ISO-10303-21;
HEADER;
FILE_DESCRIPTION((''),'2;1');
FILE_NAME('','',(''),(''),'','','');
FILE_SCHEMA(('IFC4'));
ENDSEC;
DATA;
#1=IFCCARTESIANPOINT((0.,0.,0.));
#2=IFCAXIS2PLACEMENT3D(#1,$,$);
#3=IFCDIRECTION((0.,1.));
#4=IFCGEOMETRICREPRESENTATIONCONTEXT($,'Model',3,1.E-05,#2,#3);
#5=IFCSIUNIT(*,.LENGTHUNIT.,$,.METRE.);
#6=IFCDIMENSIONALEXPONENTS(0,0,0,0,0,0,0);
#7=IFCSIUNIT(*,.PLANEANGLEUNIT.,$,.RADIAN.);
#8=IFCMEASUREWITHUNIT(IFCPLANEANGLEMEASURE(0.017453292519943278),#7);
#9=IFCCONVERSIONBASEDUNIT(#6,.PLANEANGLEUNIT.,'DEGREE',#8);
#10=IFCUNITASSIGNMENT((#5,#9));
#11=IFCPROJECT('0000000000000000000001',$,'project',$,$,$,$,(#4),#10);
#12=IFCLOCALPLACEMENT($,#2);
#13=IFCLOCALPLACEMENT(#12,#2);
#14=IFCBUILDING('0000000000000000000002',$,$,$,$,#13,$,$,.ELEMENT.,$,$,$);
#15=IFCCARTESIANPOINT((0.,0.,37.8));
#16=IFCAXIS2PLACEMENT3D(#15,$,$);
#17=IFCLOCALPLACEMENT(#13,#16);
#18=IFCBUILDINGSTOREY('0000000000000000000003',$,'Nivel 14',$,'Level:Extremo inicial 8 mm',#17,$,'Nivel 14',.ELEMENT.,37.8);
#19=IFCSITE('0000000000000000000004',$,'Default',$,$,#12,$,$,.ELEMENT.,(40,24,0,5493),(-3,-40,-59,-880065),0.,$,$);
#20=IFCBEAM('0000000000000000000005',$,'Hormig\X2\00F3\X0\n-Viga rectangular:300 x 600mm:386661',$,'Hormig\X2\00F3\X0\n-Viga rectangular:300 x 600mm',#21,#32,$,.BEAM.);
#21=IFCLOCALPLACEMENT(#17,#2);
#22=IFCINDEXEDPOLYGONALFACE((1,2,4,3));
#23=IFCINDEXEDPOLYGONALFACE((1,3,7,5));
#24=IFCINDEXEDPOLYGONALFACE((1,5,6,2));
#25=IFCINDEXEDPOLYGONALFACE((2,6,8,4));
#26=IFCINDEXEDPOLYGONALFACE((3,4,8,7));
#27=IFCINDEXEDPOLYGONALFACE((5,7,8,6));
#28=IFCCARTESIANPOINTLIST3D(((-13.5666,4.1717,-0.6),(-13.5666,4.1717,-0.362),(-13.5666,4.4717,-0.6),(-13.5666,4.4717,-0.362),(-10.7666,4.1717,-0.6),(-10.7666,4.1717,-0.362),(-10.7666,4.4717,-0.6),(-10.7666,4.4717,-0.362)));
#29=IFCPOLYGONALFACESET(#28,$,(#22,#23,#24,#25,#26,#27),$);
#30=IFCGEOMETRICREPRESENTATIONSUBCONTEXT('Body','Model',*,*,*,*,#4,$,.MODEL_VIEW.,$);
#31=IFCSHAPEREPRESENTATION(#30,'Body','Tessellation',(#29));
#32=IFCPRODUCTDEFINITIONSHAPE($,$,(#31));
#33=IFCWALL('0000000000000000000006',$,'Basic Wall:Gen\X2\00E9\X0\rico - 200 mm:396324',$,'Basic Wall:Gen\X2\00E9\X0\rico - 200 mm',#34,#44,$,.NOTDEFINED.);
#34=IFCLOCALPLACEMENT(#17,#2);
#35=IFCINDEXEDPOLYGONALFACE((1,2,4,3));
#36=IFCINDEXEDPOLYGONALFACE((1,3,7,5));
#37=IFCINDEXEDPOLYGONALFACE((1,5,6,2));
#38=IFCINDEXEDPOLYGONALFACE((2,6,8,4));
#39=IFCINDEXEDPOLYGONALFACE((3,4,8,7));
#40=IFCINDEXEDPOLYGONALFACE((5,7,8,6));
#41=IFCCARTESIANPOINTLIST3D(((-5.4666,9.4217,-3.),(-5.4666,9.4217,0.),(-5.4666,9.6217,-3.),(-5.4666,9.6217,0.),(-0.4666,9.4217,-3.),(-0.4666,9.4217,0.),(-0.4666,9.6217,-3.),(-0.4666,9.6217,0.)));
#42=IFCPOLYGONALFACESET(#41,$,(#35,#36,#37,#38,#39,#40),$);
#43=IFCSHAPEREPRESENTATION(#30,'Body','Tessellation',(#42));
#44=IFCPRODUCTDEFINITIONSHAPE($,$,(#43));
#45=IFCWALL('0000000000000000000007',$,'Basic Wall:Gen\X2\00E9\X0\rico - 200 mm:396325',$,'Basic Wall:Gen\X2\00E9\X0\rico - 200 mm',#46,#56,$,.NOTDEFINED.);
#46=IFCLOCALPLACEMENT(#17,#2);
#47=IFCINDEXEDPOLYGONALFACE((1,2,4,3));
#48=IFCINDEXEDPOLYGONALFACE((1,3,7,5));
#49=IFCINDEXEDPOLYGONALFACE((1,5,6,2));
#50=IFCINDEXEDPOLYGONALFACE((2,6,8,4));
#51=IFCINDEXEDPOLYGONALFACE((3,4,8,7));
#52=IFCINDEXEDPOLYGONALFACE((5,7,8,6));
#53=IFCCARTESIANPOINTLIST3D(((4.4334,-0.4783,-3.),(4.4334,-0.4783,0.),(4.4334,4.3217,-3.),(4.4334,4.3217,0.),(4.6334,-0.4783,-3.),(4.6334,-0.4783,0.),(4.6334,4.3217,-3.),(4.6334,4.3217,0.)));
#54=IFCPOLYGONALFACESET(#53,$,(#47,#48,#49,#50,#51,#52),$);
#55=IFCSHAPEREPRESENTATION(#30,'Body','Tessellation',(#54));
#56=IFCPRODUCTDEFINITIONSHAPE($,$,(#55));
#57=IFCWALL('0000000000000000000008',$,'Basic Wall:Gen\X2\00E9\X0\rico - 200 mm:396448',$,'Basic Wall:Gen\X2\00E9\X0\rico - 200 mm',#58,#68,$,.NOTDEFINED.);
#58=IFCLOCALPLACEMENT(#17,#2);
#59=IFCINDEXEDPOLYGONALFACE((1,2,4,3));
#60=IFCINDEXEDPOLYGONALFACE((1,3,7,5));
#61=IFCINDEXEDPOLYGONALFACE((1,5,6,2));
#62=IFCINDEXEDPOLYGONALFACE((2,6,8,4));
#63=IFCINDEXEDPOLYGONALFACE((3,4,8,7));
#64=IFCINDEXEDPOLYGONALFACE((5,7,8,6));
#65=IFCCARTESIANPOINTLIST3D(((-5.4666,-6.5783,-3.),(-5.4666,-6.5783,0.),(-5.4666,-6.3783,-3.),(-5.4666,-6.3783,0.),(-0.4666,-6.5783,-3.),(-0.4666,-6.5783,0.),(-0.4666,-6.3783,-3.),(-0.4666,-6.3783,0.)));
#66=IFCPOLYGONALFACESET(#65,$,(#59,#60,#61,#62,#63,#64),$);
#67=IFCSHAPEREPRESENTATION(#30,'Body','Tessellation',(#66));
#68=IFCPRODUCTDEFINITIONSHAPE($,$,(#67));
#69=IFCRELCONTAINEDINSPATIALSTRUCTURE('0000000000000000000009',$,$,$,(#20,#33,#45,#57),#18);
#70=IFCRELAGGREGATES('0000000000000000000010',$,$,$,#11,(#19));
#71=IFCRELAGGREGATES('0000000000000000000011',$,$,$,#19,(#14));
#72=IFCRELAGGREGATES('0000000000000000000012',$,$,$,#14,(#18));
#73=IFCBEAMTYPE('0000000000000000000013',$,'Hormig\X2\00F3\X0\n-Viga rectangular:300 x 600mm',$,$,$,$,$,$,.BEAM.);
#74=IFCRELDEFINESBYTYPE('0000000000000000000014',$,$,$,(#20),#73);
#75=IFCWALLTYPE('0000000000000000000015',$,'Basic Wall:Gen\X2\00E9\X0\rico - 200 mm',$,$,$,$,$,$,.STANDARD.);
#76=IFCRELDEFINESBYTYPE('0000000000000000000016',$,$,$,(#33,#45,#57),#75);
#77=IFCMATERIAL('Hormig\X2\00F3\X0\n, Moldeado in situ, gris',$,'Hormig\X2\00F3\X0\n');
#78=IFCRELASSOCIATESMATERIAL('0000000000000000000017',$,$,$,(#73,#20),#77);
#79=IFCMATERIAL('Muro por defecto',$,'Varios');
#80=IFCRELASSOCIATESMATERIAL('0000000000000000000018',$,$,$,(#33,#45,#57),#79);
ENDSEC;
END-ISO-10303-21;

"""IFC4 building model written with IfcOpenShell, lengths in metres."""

from ifc_helpers import new_model, entity, si_unit, converted_unit, direction, frame, origin, place, context, subcontext, project, spatial, indexed_curve, outline, extrude, source, transform, mapped, material, type_object, type_shapes, element, save


model = new_model("IFC4")

# Units and contexts
model_context = context("Model", 3, precision=1e-05, world=origin(), true_north=direction((0.0, 1.0)))
body_context = subcontext(model_context, "Body", "Model", "MODEL_VIEW")
ifc_project = project(units=[si_unit("LENGTHUNIT", "METRE"), converted_unit("PLANEANGLEUNIT", "DEGREE", entity("IfcPlaneAngleMeasure", 0.017453292519943278), si_unit("PLANEANGLEUNIT", "RADIAN"), dimensions=[0, 0, 0, 0, 0, 0, 0])], contexts=[model_context])

# Site, building, storey
site_placement = place(None, origin())
site = spatial("IfcSite", under=ifc_project, at=site_placement, Name="Default", CompositionType="ELEMENT", RefLatitude=(40, 24, 0, 5493), RefLongitude=(-3, -40, -59, -880065), RefElevation=0.0)
building_placement = place(site_placement, origin())
building = spatial("IfcBuilding", under=site, at=building_placement, CompositionType="ELEMENT")
storey_placement = place(building_placement, frame((0.0, 0.0, 37.8)))
storey = spatial("IfcBuildingStorey", under=building, at=storey_placement, Name="Nivel 14", ObjectType="Level:Extremo inicial 8 mm", LongName="Nivel 14", CompositionType="ELEMENT", Elevation=37.8)

# Shared definitions
ifc_material_1 = material(Name="Hormigón, Moldeado in situ, gris", Category="Hormigón")

# Beam
beam_type_1 = type_object("IfcBeamType", Name="Hormigón-Viga rectangular:300 x 600mm", PredefinedType="BEAM", material=ifc_material_1)
shared_shape_1 = source(origin(), body_context, "Body", "SweptSolid", [
    extrude(outline(indexed_curve([(-0.119, -0.15), (0.119, -0.15), (0.119, 0.15), (-0.119, 0.15), (-0.119, -0.15)], self_intersect=False)), frame((-10.7666, 4.3217, 37.319), z_axis=(-1.0, 0.0, 0.0), x_axis=(0.0, 0.0, -1.0)), (0.0, 0.0, 1.0), 2.8),
])
type_shapes(beam_type_1, [shared_shape_1])
beam_1_placement = place(storey_placement, frame((0.0, 0.0, -37.8)))
element("IfcBeam", 1, at=beam_1_placement, inside=storey, type_object=beam_type_1, material=ifc_material_1, Name="Hormigón-Viga rectangular:300 x 600mm:386661", ObjectType="Hormigón-Viga rectangular:300 x 600mm", PredefinedType="BEAM", context=body_context, shape_type="MappedRepresentation", body=[
    mapped(shared_shape_1, transform((0.0, 0.0, 0.0), scale=1.0)),
])

# Walls
ifc_material_2 = material(Name="Muro por defecto", Category="Varios")
wall_type = type_object("IfcWallType", Name="Basic Wall:Genérico - 200 mm", PredefinedType="STANDARD")
wall_1_placement = place(storey_placement, frame((-5.4666, 9.5217, -3.0)))
element("IfcWall", 2, at=wall_1_placement, inside=storey, type_object=wall_type, material=ifc_material_2, Name="Basic Wall:Genérico - 200 mm:396324", ObjectType="Basic Wall:Genérico - 200 mm", PredefinedType="NOTDEFINED", context=body_context, shape_type="SweptSolid", body=[
    extrude(outline(indexed_curve([(5.0, 0.1), (0.0, 0.1), (0.0, -0.1), (5.0, -0.1), (5.0, 0.1)], self_intersect=False)), origin(), (0.0, 0.0, 1.0), 3.0),
])
wall_2_placement = place(storey_placement, frame((4.5334, 4.3217, -3.0), z_axis=(0.0, 0.0, 1.0), x_axis=(0.0, -1.0, 0.0)))
element("IfcWall", 3, at=wall_2_placement, inside=storey, type_object=wall_type, material=ifc_material_2, Name="Basic Wall:Genérico - 200 mm:396325", ObjectType="Basic Wall:Genérico - 200 mm", PredefinedType="NOTDEFINED", context=body_context, shape_type="SweptSolid", body=[
    extrude(outline(indexed_curve([(4.8, 0.1), (0.0, 0.1), (0.0, -0.1), (4.8, -0.1), (4.8, 0.1)], self_intersect=False)), origin(), (0.0, 0.0, 1.0), 3.0),
])
wall_3_placement = place(storey_placement, frame((-5.4666, -6.4783, -3.0)))
element("IfcWall", 4, at=wall_3_placement, inside=storey, type_object=wall_type, material=ifc_material_2, Name="Basic Wall:Genérico - 200 mm:396448", ObjectType="Basic Wall:Genérico - 200 mm", PredefinedType="NOTDEFINED", context=body_context, shape_type="SweptSolid", body=[
    extrude(outline(indexed_curve([(5.0, 0.1), (0.0, 0.1), (0.0, -0.1), (5.0, -0.1), (5.0, 0.1)], self_intersect=False)), origin(), (0.0, 0.0, 1.0), 3.0),
])

save(model, "model.ifc")
